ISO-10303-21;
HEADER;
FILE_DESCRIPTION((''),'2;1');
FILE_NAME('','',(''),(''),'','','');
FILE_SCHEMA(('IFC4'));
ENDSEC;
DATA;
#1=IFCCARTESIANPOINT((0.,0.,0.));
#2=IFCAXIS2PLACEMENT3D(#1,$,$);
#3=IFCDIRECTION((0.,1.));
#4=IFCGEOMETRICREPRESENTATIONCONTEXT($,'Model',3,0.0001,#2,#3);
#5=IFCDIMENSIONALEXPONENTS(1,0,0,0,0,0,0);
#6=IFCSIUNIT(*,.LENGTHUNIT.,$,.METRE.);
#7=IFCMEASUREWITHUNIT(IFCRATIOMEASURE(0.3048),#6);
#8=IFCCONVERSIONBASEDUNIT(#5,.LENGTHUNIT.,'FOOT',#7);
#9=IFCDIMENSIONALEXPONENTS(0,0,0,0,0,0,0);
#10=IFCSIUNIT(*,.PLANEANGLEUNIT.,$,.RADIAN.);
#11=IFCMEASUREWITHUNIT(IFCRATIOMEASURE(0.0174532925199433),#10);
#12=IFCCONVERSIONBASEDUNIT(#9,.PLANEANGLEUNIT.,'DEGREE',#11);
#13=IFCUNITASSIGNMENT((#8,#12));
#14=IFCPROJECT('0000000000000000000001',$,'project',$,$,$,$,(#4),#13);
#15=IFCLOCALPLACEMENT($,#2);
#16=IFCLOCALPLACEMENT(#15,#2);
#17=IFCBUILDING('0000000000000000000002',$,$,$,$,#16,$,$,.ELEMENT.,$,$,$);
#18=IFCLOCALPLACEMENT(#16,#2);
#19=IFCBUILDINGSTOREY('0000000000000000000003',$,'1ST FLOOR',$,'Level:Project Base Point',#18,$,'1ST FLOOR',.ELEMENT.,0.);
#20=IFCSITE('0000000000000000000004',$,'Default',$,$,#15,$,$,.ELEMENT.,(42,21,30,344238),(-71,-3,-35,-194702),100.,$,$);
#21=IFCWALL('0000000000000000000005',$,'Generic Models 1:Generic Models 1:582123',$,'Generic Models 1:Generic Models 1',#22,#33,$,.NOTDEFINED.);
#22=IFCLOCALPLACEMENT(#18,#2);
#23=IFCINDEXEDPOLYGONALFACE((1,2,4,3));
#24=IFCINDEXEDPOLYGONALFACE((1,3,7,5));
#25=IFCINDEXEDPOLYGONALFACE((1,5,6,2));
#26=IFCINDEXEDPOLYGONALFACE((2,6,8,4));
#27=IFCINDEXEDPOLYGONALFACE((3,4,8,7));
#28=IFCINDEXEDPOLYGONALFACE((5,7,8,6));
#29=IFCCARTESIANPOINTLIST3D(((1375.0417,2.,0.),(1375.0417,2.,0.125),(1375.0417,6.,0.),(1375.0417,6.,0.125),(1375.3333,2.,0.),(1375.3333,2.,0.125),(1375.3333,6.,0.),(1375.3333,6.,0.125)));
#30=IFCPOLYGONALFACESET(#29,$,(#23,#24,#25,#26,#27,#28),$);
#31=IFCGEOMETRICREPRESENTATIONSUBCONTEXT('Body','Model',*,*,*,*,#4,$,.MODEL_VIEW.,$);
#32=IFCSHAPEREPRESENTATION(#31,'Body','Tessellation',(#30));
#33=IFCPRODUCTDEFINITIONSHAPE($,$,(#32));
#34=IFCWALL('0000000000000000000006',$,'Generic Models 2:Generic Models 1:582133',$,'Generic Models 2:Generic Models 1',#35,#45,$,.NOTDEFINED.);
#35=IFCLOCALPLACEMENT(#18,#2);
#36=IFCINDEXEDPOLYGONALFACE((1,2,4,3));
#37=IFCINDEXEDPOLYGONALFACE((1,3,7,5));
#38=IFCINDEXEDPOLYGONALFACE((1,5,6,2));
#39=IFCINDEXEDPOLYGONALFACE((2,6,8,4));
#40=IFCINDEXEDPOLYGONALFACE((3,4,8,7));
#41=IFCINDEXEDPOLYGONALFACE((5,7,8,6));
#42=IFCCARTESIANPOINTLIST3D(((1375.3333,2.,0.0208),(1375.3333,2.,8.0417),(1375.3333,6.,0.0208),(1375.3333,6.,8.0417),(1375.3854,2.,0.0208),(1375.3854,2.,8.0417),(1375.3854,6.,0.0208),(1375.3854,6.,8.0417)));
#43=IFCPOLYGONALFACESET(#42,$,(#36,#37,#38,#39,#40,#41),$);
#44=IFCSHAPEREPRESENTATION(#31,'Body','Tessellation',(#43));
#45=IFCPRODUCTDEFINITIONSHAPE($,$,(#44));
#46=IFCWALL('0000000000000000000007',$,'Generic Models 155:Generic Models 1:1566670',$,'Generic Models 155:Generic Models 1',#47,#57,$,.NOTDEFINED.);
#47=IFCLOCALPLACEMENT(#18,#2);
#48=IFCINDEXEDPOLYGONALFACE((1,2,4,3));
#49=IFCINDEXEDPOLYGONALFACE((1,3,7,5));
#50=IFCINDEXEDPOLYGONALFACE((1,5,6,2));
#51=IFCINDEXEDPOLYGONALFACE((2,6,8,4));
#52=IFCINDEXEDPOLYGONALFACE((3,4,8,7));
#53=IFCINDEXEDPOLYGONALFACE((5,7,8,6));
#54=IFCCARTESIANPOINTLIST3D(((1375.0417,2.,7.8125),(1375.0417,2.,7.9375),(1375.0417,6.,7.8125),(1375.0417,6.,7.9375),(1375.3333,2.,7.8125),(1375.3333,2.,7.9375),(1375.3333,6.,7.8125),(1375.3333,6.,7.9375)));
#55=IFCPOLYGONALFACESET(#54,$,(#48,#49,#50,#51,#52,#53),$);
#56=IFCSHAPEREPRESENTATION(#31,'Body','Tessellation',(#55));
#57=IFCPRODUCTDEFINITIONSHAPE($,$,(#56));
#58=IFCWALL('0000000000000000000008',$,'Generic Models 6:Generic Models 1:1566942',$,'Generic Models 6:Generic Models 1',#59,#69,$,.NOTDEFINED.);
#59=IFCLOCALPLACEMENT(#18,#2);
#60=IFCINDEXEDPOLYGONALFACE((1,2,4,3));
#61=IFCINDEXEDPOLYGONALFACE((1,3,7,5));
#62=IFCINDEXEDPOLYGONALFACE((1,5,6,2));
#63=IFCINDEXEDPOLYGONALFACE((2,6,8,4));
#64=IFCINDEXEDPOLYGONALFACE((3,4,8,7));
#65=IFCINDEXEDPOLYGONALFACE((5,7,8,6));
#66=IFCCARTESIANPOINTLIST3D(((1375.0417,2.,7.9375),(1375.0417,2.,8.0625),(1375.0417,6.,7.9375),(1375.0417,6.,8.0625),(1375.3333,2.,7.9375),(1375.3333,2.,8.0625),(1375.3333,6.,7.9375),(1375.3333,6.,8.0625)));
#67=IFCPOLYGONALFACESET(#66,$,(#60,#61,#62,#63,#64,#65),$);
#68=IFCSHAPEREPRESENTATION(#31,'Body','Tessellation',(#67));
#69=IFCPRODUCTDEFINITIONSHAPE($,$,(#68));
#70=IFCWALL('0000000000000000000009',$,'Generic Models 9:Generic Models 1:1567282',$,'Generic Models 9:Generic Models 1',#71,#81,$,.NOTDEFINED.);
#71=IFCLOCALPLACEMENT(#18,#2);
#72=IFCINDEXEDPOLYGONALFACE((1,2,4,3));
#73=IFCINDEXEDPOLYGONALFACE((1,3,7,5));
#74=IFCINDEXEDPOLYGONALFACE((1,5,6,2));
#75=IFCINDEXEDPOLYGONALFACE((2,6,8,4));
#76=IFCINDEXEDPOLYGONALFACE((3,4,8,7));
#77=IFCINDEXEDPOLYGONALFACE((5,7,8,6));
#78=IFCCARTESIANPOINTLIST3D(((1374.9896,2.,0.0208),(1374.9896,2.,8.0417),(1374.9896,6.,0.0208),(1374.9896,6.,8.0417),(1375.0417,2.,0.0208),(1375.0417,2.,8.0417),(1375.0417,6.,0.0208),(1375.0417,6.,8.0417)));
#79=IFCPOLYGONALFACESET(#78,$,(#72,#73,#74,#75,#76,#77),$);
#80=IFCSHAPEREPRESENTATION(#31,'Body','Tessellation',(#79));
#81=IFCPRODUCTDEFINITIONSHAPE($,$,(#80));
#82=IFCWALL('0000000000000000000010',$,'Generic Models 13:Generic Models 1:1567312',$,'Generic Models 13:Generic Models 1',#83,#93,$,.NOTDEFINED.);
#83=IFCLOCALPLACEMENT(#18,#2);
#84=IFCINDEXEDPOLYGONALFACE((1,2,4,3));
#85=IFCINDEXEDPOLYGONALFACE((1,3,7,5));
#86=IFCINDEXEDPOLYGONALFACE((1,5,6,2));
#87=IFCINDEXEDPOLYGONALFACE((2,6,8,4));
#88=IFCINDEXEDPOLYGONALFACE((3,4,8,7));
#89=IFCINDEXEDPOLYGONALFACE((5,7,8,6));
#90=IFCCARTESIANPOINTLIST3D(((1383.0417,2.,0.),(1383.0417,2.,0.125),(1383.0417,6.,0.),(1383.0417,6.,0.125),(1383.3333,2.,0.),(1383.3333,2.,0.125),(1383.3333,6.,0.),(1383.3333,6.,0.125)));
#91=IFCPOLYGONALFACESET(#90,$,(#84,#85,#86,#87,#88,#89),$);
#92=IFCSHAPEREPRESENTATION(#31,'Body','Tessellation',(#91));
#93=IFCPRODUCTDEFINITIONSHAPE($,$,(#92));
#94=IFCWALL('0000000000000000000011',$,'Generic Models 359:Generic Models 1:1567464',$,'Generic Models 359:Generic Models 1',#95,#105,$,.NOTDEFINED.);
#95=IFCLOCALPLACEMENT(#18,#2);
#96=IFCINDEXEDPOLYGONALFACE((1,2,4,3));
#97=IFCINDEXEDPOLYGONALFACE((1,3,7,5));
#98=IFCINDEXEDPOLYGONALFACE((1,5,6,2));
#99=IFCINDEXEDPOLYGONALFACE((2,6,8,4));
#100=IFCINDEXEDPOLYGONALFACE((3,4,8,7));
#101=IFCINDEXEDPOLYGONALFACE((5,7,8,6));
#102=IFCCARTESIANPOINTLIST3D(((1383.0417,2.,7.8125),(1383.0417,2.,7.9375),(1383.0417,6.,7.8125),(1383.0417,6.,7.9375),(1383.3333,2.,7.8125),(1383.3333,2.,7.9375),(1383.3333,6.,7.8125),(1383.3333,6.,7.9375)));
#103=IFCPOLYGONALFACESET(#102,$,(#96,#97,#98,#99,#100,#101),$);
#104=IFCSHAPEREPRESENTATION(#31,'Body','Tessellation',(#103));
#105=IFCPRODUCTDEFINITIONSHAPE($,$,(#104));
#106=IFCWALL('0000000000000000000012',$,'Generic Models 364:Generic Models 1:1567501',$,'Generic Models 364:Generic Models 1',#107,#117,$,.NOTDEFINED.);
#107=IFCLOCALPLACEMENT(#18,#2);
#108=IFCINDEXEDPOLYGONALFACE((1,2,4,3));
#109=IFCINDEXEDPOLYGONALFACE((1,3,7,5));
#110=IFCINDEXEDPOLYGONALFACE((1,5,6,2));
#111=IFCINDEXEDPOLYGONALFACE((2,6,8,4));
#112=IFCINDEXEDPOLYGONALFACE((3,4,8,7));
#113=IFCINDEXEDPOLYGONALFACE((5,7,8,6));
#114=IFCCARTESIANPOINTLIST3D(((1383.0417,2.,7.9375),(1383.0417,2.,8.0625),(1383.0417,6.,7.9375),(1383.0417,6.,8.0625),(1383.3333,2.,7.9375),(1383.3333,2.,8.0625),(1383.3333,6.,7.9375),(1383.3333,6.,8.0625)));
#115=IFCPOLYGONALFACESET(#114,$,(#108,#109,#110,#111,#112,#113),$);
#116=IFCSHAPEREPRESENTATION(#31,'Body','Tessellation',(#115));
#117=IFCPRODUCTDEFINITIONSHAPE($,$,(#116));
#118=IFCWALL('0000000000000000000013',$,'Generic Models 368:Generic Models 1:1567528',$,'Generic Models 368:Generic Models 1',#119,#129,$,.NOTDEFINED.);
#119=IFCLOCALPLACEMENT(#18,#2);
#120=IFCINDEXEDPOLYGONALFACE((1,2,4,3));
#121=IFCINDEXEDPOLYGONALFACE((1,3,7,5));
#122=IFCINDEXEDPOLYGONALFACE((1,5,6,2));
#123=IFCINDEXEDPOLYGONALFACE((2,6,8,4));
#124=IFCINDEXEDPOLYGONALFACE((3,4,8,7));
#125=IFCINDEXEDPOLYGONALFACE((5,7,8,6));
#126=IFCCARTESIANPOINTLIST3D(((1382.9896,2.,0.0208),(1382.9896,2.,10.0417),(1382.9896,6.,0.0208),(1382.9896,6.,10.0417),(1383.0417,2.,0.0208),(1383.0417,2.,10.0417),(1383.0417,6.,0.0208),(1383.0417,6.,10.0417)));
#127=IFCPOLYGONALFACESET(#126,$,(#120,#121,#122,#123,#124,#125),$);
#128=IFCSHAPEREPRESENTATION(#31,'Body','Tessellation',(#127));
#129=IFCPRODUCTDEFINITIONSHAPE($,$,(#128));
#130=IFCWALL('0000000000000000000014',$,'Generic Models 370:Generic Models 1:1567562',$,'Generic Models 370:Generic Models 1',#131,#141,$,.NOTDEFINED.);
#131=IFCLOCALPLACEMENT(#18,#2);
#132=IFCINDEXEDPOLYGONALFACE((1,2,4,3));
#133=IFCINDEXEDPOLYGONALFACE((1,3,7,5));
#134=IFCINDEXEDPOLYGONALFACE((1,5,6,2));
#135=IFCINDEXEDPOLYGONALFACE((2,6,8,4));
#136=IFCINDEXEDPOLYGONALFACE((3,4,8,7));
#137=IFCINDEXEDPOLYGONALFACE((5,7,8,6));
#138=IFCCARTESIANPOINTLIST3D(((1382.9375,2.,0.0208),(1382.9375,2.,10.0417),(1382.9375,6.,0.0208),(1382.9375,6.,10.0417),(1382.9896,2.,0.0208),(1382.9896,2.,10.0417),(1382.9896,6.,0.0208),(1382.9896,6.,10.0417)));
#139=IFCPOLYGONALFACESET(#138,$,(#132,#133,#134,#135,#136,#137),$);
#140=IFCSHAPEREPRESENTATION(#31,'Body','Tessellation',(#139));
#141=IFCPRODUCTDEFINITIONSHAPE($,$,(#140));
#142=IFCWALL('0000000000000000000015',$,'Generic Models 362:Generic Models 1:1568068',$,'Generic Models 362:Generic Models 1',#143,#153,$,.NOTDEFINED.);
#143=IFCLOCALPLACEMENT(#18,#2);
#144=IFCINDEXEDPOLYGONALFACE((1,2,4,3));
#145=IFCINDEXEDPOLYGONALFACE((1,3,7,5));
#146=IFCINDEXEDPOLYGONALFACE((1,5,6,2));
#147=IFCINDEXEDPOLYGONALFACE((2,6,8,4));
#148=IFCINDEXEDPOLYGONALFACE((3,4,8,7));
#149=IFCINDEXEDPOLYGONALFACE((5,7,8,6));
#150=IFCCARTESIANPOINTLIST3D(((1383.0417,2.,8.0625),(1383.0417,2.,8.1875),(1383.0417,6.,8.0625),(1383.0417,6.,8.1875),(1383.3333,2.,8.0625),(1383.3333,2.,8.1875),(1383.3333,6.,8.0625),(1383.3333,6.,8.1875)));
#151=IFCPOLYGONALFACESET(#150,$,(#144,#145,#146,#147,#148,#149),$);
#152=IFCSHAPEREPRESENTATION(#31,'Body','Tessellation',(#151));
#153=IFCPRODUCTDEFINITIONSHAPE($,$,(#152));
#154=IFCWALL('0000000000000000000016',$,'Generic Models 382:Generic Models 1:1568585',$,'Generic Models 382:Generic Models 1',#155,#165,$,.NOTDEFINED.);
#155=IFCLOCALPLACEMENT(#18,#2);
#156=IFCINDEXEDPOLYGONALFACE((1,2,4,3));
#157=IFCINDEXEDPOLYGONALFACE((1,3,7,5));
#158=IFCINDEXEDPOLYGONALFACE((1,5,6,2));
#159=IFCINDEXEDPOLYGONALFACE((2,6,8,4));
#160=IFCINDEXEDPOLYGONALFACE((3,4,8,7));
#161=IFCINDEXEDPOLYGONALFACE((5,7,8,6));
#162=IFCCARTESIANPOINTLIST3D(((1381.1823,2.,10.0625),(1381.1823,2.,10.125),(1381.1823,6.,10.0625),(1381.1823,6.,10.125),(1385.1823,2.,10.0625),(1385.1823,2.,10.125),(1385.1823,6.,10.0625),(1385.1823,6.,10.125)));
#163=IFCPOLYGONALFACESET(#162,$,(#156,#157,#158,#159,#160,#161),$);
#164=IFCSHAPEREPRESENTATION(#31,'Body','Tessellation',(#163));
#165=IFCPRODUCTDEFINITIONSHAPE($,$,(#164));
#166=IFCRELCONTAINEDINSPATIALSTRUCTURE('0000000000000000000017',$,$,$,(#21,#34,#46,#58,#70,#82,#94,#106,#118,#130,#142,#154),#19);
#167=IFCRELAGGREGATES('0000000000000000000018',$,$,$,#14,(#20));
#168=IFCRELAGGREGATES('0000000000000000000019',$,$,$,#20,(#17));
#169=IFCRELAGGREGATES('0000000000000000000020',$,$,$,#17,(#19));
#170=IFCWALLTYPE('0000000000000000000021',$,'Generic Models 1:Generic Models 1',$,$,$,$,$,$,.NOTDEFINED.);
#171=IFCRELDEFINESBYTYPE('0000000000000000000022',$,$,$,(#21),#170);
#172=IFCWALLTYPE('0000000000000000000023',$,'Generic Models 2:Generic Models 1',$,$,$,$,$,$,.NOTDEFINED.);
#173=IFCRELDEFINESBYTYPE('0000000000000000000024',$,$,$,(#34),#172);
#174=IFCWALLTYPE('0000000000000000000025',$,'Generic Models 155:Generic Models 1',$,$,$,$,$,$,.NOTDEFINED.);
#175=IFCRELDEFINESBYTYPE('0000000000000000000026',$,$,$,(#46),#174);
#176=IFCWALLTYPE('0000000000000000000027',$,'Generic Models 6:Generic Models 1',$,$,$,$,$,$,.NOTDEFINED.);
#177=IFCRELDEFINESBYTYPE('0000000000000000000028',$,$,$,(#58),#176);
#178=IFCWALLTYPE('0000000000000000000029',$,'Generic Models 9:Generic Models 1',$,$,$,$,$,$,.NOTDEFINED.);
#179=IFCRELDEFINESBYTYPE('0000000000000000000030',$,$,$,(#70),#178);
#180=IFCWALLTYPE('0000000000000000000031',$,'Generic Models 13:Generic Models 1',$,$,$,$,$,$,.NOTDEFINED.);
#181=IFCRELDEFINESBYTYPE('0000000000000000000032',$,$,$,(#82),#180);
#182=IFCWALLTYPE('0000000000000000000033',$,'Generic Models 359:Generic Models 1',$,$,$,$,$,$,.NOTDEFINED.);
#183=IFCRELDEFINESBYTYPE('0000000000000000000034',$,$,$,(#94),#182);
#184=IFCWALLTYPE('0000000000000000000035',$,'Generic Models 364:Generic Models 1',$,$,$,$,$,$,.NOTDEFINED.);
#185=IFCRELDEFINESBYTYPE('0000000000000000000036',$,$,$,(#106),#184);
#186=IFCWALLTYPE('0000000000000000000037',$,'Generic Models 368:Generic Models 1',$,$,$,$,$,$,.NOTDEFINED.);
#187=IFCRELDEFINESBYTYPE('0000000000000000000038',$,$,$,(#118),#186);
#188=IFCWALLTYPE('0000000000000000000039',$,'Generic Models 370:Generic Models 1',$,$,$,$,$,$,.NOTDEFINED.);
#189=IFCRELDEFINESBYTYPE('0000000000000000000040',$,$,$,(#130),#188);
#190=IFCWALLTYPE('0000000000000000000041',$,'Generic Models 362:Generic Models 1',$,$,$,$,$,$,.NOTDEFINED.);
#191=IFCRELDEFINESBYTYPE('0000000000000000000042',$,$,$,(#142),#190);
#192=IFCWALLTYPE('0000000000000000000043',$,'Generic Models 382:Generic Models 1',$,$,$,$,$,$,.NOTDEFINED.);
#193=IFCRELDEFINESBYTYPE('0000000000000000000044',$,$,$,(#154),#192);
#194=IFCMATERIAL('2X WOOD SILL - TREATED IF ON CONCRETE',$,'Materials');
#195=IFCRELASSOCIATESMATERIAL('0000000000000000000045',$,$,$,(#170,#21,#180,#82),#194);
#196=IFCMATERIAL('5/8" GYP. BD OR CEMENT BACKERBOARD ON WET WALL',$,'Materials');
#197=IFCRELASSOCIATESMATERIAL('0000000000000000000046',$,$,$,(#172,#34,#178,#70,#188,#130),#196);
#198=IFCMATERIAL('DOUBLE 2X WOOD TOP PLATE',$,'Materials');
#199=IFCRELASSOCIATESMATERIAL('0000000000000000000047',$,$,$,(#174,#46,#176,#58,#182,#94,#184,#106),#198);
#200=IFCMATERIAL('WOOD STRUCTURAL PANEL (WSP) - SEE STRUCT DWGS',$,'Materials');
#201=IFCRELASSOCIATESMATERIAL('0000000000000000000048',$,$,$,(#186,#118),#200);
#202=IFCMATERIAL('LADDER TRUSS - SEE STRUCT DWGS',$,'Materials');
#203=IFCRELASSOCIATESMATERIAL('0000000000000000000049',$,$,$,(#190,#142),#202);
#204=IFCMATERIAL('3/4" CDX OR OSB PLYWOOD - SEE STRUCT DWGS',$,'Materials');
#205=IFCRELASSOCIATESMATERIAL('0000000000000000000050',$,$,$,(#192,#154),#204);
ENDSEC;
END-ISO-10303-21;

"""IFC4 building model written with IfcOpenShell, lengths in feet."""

from ifc_helpers import new_model, entity, si_unit, converted_unit, direction, frame, frame_2d, origin, origin_2d_with_axis, place, context, subcontext, project, spatial, rectangle, extrude, material, type_object, element, save


model = new_model("IFC4")

# Units and contexts
model_context = context("Model", 3, precision=0.0001, world=origin(), true_north=direction((0.0, 1.0)))
body_context = subcontext(model_context, "Body", "Model", "MODEL_VIEW")
ifc_project = project(units=[converted_unit("LENGTHUNIT", "FOOT", entity("IfcRatioMeasure", 0.3048), si_unit("LENGTHUNIT", "METRE"), dimensions=[1, 0, 0, 0, 0, 0, 0]), converted_unit("PLANEANGLEUNIT", "DEGREE", entity("IfcRatioMeasure", 0.0174532925199433), si_unit("PLANEANGLEUNIT", "RADIAN"), dimensions=[0, 0, 0, 0, 0, 0, 0])], contexts=[model_context])

# Site, building, storey
site_placement = place(None, origin())
site = spatial("IfcSite", under=ifc_project, at=site_placement, Name="Default", CompositionType="ELEMENT", RefLatitude=(42, 21, 30, 344238), RefLongitude=(-71, -3, -35, -194702), RefElevation=100.0)
building_placement = place(site_placement, origin())
building = spatial("IfcBuilding", under=site, at=building_placement, CompositionType="ELEMENT")
storey_placement = place(building_placement, origin())
storey = spatial("IfcBuildingStorey", under=building, at=storey_placement, Name="1ST FLOOR", ObjectType="Level:Project Base Point", LongName="1ST FLOOR", CompositionType="ELEMENT", Elevation=0.0)

# Walls
ifc_material_1 = material(Name="2X WOOD SILL - TREATED IF ON CONCRETE", Category="Materials")
wall_type_1 = type_object("IfcWallType", Name="Generic Models 1:Generic Models 1", PredefinedType="NOTDEFINED", material=ifc_material_1)
wall_1_placement = place(storey_placement, frame((1375.0417, 2.0, 0.0), z_axis=(0.0, 0.0, 1.0), x_axis=(0.0, 1.0, 0.0)))
element("IfcWall", 1, at=wall_1_placement, inside=storey, type_object=wall_type_1, material=ifc_material_1, Name="Generic Models 1:Generic Models 1:582123", ObjectType="Generic Models 1:Generic Models 1", PredefinedType="NOTDEFINED", context=body_context, shape_type="SweptSolid", body=[
    extrude(rectangle(XDim=4.0, YDim=0.2917, at=frame_2d((0.0, 0.0), x_axis=(1.0, 0.0))), frame((2.0, -0.1458, 0.0)), (0.0, 0.0, 1.0), 0.125),
])
ifc_material_2 = material(Name="5/8\" GYP. BD OR CEMENT BACKERBOARD ON WET WALL", Category="Materials")
wall_type_2 = type_object("IfcWallType", Name="Generic Models 2:Generic Models 1", PredefinedType="NOTDEFINED", material=ifc_material_2)
wall_2_placement = place(storey_placement, frame((1375.3333, 2.0, 0.0208), z_axis=(0.0, 0.0, 1.0), x_axis=(0.0, 1.0, 0.0)))
element("IfcWall", 2, at=wall_2_placement, inside=storey, type_object=wall_type_2, material=ifc_material_2, Name="Generic Models 2:Generic Models 1:582133", ObjectType="Generic Models 2:Generic Models 1", PredefinedType="NOTDEFINED", context=body_context, shape_type="SweptSolid", body=[
    extrude(rectangle(XDim=4.0, YDim=0.0521, at=frame_2d((0.0, 0.0), x_axis=(1.0, 0.0))), frame((2.0, -0.026, 0.0)), (0.0, 0.0, 1.0), 8.0208),
])
ifc_material_3 = material(Name="DOUBLE 2X WOOD TOP PLATE", Category="Materials")
wall_type_3 = type_object("IfcWallType", Name="Generic Models 155:Generic Models 1", PredefinedType="NOTDEFINED", material=ifc_material_3)
wall_3_placement = place(storey_placement, frame((1375.0417, 2.0, 7.8125), z_axis=(0.0, 0.0, 1.0), x_axis=(0.0, 1.0, 0.0)))
element("IfcWall", 3, at=wall_3_placement, inside=storey, type_object=wall_type_3, material=ifc_material_3, Name="Generic Models 155:Generic Models 1:1566670", ObjectType="Generic Models 155:Generic Models 1", PredefinedType="NOTDEFINED", context=body_context, shape_type="SweptSolid", body=[
    extrude(rectangle(XDim=4.0, YDim=0.2917, at=frame_2d((0.0, 0.0), x_axis=(1.0, 0.0))), frame((2.0, -0.1458, 0.0)), (0.0, 0.0, 1.0), 0.125),
])
wall_type_4 = type_object("IfcWallType", Name="Generic Models 6:Generic Models 1", PredefinedType="NOTDEFINED", material=ifc_material_3)
wall_4_placement = place(storey_placement, frame((1375.0417, 2.0, 7.9375), z_axis=(0.0, 0.0, 1.0), x_axis=(0.0, 1.0, 0.0)))
element("IfcWall", 4, at=wall_4_placement, inside=storey, type_object=wall_type_4, material=ifc_material_3, Name="Generic Models 6:Generic Models 1:1566942", ObjectType="Generic Models 6:Generic Models 1", PredefinedType="NOTDEFINED", context=body_context, shape_type="SweptSolid", body=[
    extrude(rectangle(XDim=4.0, YDim=0.2917, at=frame_2d((0.0, 0.0), x_axis=(1.0, 0.0))), frame((2.0, -0.1458, 0.0)), (0.0, 0.0, 1.0), 0.125),
])
wall_type_5 = type_object("IfcWallType", Name="Generic Models 9:Generic Models 1", PredefinedType="NOTDEFINED", material=ifc_material_2)
wall_5_placement = place(storey_placement, frame((1374.9896, 2.0, 0.0208), z_axis=(0.0, 0.0, 1.0), x_axis=(0.0, 1.0, 0.0)))
element("IfcWall", 5, at=wall_5_placement, inside=storey, type_object=wall_type_5, material=ifc_material_2, Name="Generic Models 9:Generic Models 1:1567282", ObjectType="Generic Models 9:Generic Models 1", PredefinedType="NOTDEFINED", context=body_context, shape_type="SweptSolid", body=[
    extrude(rectangle(XDim=4.0, YDim=0.0521, at=frame_2d((0.0, 0.0), x_axis=(1.0, 0.0))), frame((2.0, -0.026, 0.0)), (0.0, 0.0, 1.0), 8.0208),
])
wall_type_6 = type_object("IfcWallType", Name="Generic Models 13:Generic Models 1", PredefinedType="NOTDEFINED", material=ifc_material_1)
wall_6_placement = place(storey_placement, frame((1383.0417, 2.0, 0.0), z_axis=(0.0, 0.0, 1.0), x_axis=(0.0, 1.0, 0.0)))
element("IfcWall", 6, at=wall_6_placement, inside=storey, type_object=wall_type_6, material=ifc_material_1, Name="Generic Models 13:Generic Models 1:1567312", ObjectType="Generic Models 13:Generic Models 1", PredefinedType="NOTDEFINED", context=body_context, shape_type="SweptSolid", body=[
    extrude(rectangle(XDim=4.0, YDim=0.2917, at=frame_2d((0.0, 0.0), x_axis=(1.0, 0.0))), frame((2.0, -0.1458, 0.0)), (0.0, 0.0, 1.0), 0.125),
])
wall_type_7 = type_object("IfcWallType", Name="Generic Models 359:Generic Models 1", PredefinedType="NOTDEFINED", material=ifc_material_3)
wall_7_placement = place(storey_placement, frame((1383.0417, 2.0, 7.8125), z_axis=(0.0, 0.0, 1.0), x_axis=(0.0, 1.0, 0.0)))
element("IfcWall", 7, at=wall_7_placement, inside=storey, type_object=wall_type_7, material=ifc_material_3, Name="Generic Models 359:Generic Models 1:1567464", ObjectType="Generic Models 359:Generic Models 1", PredefinedType="NOTDEFINED", context=body_context, shape_type="SweptSolid", body=[
    extrude(rectangle(XDim=4.0, YDim=0.2917, at=frame_2d((0.0, 0.0), x_axis=(1.0, 0.0))), frame((2.0, -0.1458, 0.0)), (0.0, 0.0, 1.0), 0.125),
])
wall_type_8 = type_object("IfcWallType", Name="Generic Models 364:Generic Models 1", PredefinedType="NOTDEFINED", material=ifc_material_3)
wall_8_placement = place(storey_placement, frame((1383.0417, 2.0, 7.9375), z_axis=(0.0, 0.0, 1.0), x_axis=(0.0, 1.0, 0.0)))
element("IfcWall", 8, at=wall_8_placement, inside=storey, type_object=wall_type_8, material=ifc_material_3, Name="Generic Models 364:Generic Models 1:1567501", ObjectType="Generic Models 364:Generic Models 1", PredefinedType="NOTDEFINED", context=body_context, shape_type="SweptSolid", body=[
    extrude(rectangle(XDim=4.0, YDim=0.2917, at=frame_2d((0.0, 0.0), x_axis=(1.0, 0.0))), frame((2.0, -0.1458, 0.0)), (0.0, 0.0, 1.0), 0.125),
])
ifc_material_4 = material(Name="WOOD STRUCTURAL PANEL (WSP) - SEE STRUCT DWGS", Category="Materials")
wall_type_9 = type_object("IfcWallType", Name="Generic Models 368:Generic Models 1", PredefinedType="NOTDEFINED", material=ifc_material_4)
wall_9_placement = place(storey_placement, frame((1382.9896, 2.0, 0.0208), z_axis=(0.0, 0.0, 1.0), x_axis=(0.0, 1.0, 0.0)))
element("IfcWall", 9, at=wall_9_placement, inside=storey, type_object=wall_type_9, material=ifc_material_4, Name="Generic Models 368:Generic Models 1:1567528", ObjectType="Generic Models 368:Generic Models 1", PredefinedType="NOTDEFINED", context=body_context, shape_type="SweptSolid", body=[
    extrude(rectangle(XDim=4.0, YDim=0.0521, at=frame_2d((0.0, 0.0), x_axis=(1.0, 0.0))), frame((2.0, -0.026, 0.0)), (0.0, 0.0, 1.0), 10.0208),
])
wall_type_10 = type_object("IfcWallType", Name="Generic Models 370:Generic Models 1", PredefinedType="NOTDEFINED", material=ifc_material_2)
wall_10_placement = place(storey_placement, frame((1382.9375, 2.0, 0.0208), z_axis=(0.0, 0.0, 1.0), x_axis=(0.0, 1.0, 0.0)))
element("IfcWall", 10, at=wall_10_placement, inside=storey, type_object=wall_type_10, material=ifc_material_2, Name="Generic Models 370:Generic Models 1:1567562", ObjectType="Generic Models 370:Generic Models 1", PredefinedType="NOTDEFINED", context=body_context, shape_type="SweptSolid", body=[
    extrude(rectangle(XDim=4.0, YDim=0.0521, at=frame_2d((0.0, 0.0), x_axis=(1.0, 0.0))), frame((2.0, -0.026, 0.0)), (0.0, 0.0, 1.0), 10.0208),
])
ifc_material_5 = material(Name="LADDER TRUSS - SEE STRUCT DWGS", Category="Materials")
wall_type_11 = type_object("IfcWallType", Name="Generic Models 362:Generic Models 1", PredefinedType="NOTDEFINED", material=ifc_material_5)
wall_11_placement = place(storey_placement, frame((1383.0417, 2.0, 8.0625), z_axis=(0.0, 0.0, 1.0), x_axis=(0.0, 1.0, 0.0)))
element("IfcWall", 11, at=wall_11_placement, inside=storey, type_object=wall_type_11, material=ifc_material_5, Name="Generic Models 362:Generic Models 1:1568068", ObjectType="Generic Models 362:Generic Models 1", PredefinedType="NOTDEFINED", context=body_context, shape_type="SweptSolid", body=[
    extrude(rectangle(XDim=4.0, YDim=0.2917, at=origin_2d_with_axis()), frame((2.0, -0.1458, 0.0)), (0.0, 0.0, 1.0), 0.125),
])
ifc_material_6 = material(Name="3/4\" CDX OR OSB PLYWOOD - SEE STRUCT DWGS", Category="Materials")
wall_type_12 = type_object("IfcWallType", Name="Generic Models 382:Generic Models 1", PredefinedType="NOTDEFINED", material=ifc_material_6)
wall_12_placement = place(storey_placement, frame((1381.1823, 2.0, 10.0625), z_axis=(0.0, 0.0, 1.0), x_axis=(0.0, 1.0, 0.0)))
element("IfcWall", 12, at=wall_12_placement, inside=storey, type_object=wall_type_12, material=ifc_material_6, Name="Generic Models 382:Generic Models 1:1568585", ObjectType="Generic Models 382:Generic Models 1", PredefinedType="NOTDEFINED", context=body_context, shape_type="SweptSolid", body=[
    extrude(rectangle(XDim=4.0, YDim=4.0, at=frame_2d((0.0, 0.0), x_axis=(1.0, 0.0))), frame((2.0, -2.0, 0.0)), (0.0, 0.0, 1.0), 0.0625),
])

save(model, "model.ifc")
